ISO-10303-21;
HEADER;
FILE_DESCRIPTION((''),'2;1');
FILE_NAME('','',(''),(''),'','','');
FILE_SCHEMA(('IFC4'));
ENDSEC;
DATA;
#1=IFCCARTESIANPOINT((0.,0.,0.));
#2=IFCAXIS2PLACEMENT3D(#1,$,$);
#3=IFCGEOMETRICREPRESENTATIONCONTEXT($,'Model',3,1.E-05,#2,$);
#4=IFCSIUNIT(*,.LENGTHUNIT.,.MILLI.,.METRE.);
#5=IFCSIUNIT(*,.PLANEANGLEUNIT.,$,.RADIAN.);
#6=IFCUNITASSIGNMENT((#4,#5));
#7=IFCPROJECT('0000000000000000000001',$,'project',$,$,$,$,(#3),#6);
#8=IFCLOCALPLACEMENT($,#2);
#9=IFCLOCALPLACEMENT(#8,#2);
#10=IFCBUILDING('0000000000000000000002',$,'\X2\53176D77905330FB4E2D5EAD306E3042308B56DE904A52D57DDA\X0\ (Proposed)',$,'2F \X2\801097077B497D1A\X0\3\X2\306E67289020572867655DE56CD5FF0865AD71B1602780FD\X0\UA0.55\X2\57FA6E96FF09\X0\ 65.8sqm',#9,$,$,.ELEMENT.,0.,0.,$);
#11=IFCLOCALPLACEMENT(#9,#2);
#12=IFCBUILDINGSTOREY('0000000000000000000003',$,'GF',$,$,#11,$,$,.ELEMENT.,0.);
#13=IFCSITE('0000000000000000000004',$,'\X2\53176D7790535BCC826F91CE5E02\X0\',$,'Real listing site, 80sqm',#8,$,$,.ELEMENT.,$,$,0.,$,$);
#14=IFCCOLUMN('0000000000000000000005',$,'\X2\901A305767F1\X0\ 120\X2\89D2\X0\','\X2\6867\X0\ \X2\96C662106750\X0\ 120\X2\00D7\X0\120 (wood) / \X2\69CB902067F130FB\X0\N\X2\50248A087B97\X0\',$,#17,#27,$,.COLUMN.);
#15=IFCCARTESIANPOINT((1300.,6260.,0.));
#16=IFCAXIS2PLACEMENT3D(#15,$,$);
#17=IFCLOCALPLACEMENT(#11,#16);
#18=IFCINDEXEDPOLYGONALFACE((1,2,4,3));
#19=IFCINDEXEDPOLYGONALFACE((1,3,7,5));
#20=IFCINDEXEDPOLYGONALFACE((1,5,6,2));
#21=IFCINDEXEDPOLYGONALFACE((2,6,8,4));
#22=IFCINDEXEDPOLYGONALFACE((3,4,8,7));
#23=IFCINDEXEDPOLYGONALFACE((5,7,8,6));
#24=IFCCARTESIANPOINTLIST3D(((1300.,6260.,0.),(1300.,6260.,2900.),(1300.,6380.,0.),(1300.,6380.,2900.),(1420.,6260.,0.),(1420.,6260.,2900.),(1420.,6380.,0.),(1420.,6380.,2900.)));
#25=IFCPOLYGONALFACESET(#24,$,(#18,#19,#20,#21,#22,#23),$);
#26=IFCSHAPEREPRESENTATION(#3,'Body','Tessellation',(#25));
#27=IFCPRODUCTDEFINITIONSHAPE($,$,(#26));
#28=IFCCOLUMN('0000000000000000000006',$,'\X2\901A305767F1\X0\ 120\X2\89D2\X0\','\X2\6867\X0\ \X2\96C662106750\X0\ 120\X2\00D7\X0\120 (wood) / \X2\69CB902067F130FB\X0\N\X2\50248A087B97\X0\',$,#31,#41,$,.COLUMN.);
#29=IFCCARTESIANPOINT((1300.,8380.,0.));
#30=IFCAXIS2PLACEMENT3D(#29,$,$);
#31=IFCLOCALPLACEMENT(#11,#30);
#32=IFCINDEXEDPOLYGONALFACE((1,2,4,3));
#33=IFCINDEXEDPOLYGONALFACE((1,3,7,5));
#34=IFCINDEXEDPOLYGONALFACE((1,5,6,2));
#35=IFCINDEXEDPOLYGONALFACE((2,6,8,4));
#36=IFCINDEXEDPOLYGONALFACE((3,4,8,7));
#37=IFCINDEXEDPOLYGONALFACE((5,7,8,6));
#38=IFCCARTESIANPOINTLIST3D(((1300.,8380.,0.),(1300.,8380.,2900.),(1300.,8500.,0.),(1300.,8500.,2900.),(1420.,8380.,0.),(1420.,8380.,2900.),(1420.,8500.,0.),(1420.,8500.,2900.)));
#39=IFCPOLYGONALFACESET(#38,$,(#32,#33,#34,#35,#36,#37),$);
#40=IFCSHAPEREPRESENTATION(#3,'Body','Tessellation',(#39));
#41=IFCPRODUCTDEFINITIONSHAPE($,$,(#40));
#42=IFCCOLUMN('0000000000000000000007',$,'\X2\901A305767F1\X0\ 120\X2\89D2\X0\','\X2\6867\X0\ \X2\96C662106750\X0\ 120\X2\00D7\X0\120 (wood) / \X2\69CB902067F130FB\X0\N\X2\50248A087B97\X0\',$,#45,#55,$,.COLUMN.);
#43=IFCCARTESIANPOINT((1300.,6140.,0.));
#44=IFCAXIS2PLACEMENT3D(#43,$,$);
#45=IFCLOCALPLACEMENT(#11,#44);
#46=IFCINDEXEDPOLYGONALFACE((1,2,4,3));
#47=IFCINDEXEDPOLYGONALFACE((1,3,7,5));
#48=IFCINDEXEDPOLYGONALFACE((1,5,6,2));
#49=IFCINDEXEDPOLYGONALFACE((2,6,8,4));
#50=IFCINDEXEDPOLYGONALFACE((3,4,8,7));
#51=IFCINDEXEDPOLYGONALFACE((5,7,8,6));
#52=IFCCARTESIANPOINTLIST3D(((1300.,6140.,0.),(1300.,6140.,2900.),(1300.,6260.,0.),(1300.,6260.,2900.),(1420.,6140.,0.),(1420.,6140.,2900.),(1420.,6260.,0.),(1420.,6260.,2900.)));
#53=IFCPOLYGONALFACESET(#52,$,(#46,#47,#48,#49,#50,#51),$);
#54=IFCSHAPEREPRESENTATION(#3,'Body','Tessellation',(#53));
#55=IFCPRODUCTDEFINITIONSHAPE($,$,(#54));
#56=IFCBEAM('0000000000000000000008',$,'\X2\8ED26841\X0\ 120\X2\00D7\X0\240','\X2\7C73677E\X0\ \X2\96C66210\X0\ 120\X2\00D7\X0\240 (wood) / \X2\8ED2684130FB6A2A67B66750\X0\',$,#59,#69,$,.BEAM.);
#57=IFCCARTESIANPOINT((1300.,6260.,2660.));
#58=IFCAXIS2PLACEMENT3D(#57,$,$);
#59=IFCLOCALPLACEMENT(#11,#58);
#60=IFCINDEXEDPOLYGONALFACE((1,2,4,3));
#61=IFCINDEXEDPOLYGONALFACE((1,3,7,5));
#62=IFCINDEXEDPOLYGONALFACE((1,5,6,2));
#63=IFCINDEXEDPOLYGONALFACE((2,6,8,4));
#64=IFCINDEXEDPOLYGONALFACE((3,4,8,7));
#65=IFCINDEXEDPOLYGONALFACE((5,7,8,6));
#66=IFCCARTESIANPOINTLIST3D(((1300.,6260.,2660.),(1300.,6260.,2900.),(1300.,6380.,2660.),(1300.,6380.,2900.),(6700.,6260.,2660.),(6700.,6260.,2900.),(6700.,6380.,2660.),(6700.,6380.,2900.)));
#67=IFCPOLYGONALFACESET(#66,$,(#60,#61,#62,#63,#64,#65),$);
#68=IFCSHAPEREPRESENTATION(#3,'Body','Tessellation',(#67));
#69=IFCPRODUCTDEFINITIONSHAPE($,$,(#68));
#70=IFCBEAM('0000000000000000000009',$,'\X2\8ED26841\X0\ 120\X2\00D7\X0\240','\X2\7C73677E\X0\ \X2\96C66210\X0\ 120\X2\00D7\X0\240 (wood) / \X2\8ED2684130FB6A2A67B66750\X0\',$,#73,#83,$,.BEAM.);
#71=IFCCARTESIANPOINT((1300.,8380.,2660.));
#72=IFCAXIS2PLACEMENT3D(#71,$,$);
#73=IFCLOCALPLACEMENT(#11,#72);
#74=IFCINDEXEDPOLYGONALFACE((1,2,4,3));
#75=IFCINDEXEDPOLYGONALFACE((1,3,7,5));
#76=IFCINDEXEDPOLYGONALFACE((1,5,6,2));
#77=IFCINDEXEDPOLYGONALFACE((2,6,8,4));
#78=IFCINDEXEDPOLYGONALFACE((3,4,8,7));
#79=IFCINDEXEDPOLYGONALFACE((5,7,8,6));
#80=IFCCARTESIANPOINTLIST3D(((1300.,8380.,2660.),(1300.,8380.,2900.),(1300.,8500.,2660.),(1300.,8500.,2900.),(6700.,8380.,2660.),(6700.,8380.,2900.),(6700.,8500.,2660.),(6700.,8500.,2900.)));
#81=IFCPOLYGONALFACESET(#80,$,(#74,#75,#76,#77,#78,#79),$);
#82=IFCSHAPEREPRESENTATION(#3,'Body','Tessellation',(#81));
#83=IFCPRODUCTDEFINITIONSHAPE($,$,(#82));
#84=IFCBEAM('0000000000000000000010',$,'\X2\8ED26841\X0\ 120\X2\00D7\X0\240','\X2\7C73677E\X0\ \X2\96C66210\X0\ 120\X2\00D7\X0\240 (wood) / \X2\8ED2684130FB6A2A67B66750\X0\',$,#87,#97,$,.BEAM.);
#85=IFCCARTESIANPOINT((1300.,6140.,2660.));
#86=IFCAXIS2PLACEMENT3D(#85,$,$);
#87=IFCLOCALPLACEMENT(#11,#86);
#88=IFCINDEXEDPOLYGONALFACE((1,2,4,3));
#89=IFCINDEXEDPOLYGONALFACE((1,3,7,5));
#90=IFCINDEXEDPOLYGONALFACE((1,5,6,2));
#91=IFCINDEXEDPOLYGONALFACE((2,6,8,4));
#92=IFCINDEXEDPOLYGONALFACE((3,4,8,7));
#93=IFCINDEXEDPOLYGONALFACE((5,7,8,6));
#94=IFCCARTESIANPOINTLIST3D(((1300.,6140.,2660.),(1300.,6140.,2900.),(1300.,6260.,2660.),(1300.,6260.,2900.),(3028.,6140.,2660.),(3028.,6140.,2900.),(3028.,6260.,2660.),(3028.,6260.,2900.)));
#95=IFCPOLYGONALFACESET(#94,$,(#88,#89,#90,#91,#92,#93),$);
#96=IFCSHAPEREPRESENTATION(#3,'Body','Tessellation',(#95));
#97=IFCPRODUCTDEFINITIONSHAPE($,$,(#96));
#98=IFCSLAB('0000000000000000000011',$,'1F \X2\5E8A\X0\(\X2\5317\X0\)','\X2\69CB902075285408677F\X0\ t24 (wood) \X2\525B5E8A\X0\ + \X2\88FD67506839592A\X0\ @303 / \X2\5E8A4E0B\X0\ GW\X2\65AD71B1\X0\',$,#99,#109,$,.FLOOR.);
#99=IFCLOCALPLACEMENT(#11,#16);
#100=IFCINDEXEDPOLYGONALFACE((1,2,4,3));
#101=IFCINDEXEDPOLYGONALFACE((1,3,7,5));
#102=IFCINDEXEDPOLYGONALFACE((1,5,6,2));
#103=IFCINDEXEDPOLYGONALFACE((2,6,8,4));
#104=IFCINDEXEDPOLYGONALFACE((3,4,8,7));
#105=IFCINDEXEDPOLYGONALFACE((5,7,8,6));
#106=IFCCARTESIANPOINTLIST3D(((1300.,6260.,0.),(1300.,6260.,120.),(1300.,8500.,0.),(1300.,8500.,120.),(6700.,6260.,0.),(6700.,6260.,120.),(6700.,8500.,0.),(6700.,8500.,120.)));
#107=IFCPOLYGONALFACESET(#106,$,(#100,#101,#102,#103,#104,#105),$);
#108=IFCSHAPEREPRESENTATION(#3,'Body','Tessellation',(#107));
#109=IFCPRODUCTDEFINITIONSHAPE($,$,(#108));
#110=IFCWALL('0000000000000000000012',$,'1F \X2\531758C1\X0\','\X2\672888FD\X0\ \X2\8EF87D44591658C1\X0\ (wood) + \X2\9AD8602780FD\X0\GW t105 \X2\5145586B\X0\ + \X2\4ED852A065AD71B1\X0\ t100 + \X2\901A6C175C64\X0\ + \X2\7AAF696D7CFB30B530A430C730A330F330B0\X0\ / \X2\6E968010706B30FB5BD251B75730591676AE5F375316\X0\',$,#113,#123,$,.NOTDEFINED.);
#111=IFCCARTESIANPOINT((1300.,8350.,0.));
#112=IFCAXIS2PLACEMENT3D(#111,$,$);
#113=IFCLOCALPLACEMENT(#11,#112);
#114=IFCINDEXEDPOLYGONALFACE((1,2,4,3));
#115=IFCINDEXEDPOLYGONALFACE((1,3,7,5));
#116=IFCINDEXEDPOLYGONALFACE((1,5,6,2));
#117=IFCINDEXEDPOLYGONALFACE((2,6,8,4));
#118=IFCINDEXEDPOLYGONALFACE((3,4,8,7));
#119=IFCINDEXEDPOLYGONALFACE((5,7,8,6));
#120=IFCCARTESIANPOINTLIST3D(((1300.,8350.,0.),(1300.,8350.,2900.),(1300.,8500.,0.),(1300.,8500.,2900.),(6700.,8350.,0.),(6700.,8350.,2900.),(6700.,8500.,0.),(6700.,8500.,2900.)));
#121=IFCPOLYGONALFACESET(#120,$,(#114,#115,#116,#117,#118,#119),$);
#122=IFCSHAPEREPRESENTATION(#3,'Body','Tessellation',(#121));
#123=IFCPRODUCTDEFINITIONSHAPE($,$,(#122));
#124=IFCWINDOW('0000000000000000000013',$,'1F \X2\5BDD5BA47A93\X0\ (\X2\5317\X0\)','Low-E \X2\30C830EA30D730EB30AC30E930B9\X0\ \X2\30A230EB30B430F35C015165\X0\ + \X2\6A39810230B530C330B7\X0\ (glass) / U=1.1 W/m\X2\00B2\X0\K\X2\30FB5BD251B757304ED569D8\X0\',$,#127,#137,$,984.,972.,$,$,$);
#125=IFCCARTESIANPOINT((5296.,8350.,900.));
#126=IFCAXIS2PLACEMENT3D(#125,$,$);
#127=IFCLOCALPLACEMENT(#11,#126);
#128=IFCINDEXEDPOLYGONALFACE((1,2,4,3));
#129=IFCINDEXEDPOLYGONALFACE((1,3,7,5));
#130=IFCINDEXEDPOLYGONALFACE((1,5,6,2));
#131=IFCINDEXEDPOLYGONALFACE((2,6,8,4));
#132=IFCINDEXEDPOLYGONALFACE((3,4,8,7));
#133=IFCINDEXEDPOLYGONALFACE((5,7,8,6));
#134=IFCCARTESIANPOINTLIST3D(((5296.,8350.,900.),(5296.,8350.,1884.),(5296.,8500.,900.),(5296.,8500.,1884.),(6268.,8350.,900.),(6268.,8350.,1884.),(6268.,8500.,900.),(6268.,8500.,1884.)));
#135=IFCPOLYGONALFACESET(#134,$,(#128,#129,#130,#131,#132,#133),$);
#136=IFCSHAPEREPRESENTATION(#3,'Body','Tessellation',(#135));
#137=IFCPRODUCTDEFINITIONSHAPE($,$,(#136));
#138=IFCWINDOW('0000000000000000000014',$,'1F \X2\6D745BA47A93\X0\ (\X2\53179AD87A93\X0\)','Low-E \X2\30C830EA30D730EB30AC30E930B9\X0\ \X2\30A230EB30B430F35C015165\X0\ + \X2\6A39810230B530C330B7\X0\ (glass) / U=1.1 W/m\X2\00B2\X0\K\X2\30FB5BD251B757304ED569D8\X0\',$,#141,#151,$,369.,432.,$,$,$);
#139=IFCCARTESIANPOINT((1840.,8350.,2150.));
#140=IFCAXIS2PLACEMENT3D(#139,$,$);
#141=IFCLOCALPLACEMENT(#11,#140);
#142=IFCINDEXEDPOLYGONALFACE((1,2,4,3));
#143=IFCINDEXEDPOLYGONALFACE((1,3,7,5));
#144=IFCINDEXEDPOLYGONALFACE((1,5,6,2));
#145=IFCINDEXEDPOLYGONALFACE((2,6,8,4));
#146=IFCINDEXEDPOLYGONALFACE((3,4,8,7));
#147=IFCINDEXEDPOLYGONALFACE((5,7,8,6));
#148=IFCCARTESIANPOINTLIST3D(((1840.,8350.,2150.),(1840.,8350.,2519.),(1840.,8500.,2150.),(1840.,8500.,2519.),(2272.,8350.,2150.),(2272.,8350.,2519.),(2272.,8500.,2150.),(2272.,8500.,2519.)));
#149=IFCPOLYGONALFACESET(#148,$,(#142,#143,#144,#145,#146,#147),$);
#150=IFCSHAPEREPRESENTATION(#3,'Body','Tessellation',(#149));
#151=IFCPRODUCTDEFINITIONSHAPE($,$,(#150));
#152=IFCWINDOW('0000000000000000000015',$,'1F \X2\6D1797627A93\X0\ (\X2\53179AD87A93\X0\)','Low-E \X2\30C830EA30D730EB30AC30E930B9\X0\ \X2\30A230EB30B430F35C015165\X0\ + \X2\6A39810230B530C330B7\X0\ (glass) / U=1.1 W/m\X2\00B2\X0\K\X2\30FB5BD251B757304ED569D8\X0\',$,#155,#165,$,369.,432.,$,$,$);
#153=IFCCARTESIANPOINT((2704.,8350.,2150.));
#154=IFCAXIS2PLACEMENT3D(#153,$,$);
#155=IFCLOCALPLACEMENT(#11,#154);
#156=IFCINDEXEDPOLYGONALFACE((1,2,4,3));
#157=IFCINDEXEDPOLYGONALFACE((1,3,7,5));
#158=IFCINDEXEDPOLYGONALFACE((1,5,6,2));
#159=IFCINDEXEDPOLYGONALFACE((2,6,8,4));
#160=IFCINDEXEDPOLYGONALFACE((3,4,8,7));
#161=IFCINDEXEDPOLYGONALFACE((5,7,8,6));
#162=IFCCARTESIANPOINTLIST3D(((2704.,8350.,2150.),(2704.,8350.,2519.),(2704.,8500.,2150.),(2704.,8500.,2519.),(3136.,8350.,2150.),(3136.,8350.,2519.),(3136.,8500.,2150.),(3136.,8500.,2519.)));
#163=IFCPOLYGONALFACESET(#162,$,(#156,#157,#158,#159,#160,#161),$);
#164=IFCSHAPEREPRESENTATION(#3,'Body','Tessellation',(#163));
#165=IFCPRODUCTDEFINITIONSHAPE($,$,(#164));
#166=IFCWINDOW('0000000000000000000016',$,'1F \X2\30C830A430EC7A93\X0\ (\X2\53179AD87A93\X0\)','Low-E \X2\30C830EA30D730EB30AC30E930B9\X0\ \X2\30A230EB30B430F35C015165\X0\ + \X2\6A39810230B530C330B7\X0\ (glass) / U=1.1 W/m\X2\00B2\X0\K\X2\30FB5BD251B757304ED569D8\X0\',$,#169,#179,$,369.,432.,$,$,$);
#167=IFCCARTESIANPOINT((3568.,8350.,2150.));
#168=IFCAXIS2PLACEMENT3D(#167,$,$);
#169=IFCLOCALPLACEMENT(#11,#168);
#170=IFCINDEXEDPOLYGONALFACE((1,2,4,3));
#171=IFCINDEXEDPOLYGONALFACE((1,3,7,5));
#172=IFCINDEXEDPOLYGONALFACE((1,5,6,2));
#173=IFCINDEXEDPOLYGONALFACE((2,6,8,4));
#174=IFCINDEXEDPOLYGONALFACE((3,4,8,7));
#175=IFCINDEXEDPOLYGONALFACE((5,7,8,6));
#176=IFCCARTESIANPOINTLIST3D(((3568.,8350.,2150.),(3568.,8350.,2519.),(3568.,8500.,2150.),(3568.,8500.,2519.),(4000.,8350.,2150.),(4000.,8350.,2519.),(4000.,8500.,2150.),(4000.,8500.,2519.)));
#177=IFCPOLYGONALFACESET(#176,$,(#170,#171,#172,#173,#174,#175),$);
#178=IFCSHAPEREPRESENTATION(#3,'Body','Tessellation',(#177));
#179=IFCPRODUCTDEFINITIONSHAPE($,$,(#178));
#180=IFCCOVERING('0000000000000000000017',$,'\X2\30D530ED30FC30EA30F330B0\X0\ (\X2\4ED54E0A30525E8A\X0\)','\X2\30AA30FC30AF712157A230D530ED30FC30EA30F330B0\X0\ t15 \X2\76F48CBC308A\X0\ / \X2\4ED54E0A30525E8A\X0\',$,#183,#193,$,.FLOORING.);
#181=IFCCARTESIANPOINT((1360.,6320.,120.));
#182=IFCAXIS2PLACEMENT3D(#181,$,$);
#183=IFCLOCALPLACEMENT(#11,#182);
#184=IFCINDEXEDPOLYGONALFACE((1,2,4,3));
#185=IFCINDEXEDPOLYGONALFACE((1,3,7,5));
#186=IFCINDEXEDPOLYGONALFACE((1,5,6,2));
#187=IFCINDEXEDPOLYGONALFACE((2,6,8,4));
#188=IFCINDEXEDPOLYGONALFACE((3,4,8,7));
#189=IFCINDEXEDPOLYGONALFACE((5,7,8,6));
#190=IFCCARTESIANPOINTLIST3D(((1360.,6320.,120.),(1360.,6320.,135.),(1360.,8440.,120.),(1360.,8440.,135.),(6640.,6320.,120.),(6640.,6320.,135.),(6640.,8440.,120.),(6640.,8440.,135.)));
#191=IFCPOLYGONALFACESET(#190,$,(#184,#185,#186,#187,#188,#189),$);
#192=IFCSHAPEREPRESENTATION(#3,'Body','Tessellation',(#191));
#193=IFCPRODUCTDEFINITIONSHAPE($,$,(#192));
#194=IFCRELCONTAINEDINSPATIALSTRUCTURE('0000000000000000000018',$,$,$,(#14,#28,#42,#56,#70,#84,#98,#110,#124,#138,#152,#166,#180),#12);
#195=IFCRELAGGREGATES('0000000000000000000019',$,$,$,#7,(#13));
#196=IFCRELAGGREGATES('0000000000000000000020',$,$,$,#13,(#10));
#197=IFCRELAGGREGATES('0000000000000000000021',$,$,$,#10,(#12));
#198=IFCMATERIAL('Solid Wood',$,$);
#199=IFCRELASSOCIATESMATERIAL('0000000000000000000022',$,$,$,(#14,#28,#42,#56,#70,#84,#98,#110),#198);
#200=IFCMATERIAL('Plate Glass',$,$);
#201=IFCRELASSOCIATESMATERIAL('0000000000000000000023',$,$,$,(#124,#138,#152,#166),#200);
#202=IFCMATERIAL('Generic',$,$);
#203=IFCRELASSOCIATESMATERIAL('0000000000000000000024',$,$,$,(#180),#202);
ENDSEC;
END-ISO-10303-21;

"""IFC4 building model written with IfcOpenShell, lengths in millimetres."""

from ifc_helpers import new_model, si_unit, frame, frame_2d, origin, place, context, project, spatial, rectangle, extrude, material, element, fill, save


model = new_model("IFC4")

# Units and contexts
model_context = context("Model", 3, precision=1e-05, world=origin())
ifc_project = project(units=[si_unit("LENGTHUNIT", "METRE", prefix="MILLI"), si_unit("PLANEANGLEUNIT", "RADIAN")], contexts=[model_context])

# Site, building, storey
site_placement = place(None, origin())
site = spatial("IfcSite", under=ifc_project, at=site_placement, Name="北海道富良野市", ObjectType="Real listing site, 80sqm", CompositionType="ELEMENT", RefElevation=0.0)
building_placement = place(site_placement, origin())
building = spatial("IfcBuilding", under=site, at=building_placement, Name="北海道・中庭のある回遊動線 (Proposed)", ObjectType="2F 耐震等級3の木造在来工法（断熱性能UA0.55基準） 65.8sqm", CompositionType="ELEMENT", ElevationOfRefHeight=0.0, ElevationOfTerrain=0.0)
storey_placement = place(building_placement, origin())
storey = spatial("IfcBuildingStorey", under=building, at=storey_placement, Name="GF", CompositionType="ELEMENT", Elevation=0.0)

# Columns
ifc_material_1 = material(Name="Solid Wood")
column_1_placement = place(storey_placement, frame((1300.0, 6260.0, 0.0)))
element("IfcColumn", 1, at=column_1_placement, inside=storey, material=ifc_material_1, Name="通し柱 120角", Description="桧 集成材 120×120 (wood) / 構造柱・N値計算", PredefinedType="COLUMN", context=model_context, shape_type="SweptSolid", body=[
    extrude(rectangle(XDim=120.0, YDim=120.0, at=frame_2d((60.0, 60.0))), frame((1300.0, 6260.0, 0.0)), (0.0, 0.0, 1.0), 2900.0),
])
column_2_placement = place(storey_placement, frame((1300.0, 8380.0, 0.0)))
element("IfcColumn", 2, at=column_2_placement, inside=storey, material=ifc_material_1, Name="通し柱 120角", Description="桧 集成材 120×120 (wood) / 構造柱・N値計算", PredefinedType="COLUMN", context=model_context, shape_type="SweptSolid", body=[
    extrude(rectangle(XDim=120.0, YDim=120.0, at=frame_2d((60.0, 60.0))), frame((1300.0, 8380.0, 0.0)), (0.0, 0.0, 1.0), 2900.0),
])
column_3_placement = place(storey_placement, frame((1300.0, 6140.0, 0.0)))
element("IfcColumn", 3, at=column_3_placement, inside=storey, material=ifc_material_1, Name="通し柱 120角", Description="桧 集成材 120×120 (wood) / 構造柱・N値計算", PredefinedType="COLUMN", context=model_context, shape_type="SweptSolid", body=[
    extrude(rectangle(XDim=120.0, YDim=120.0, at=frame_2d((60.0, 60.0))), frame((1300.0, 6140.0, 0.0)), (0.0, 0.0, 1.0), 2900.0),
])

# Beams
beam_1_placement = place(storey_placement, frame((1300.0, 6260.0, 2660.0)))
element("IfcBeam", 4, at=beam_1_placement, inside=storey, material=ifc_material_1, Name="軒桁 120×240", Description="米松 集成 120×240 (wood) / 軒桁・横架材", PredefinedType="BEAM", context=model_context, shape_type="SweptSolid", body=[
    extrude(rectangle(XDim=5400.0, YDim=120.0, at=frame_2d((2700.0, 60.0))), frame((1300.0, 6260.0, 2660.0)), (0.0, 0.0, 1.0), 240.0),
])
beam_2_placement = place(storey_placement, frame((1300.0, 8380.0, 2660.0)))
element("IfcBeam", 5, at=beam_2_placement, inside=storey, material=ifc_material_1, Name="軒桁 120×240", Description="米松 集成 120×240 (wood) / 軒桁・横架材", PredefinedType="BEAM", context=model_context, shape_type="SweptSolid", body=[
    extrude(rectangle(XDim=5400.0, YDim=120.0, at=frame_2d((2700.0, 60.0))), frame((1300.0, 8380.0, 2660.0)), (0.0, 0.0, 1.0), 240.0),
])
beam_3_placement = place(storey_placement, frame((1300.0, 6140.0, 2660.0)))
element("IfcBeam", 6, at=beam_3_placement, inside=storey, material=ifc_material_1, Name="軒桁 120×240", Description="米松 集成 120×240 (wood) / 軒桁・横架材", PredefinedType="BEAM", context=model_context, shape_type="SweptSolid", body=[
    extrude(rectangle(XDim=1728.0, YDim=120.0, at=frame_2d((864.0, 60.0))), frame((1300.0, 6140.0, 2660.0)), (0.0, 0.0, 1.0), 240.0),
])

# Slab
slab_placement = place(storey_placement, frame((1300.0, 6260.0, 0.0)))
element("IfcSlab", 7, at=slab_placement, inside=storey, material=ifc_material_1, Name="1F 床(北)", Description="構造用合板 t24 (wood) 剛床 + 製材根太 @303 / 床下 GW断熱", PredefinedType="FLOOR", context=model_context, shape_type="SweptSolid", body=[
    extrude(rectangle(XDim=5400.0, YDim=2240.0, at=frame_2d((2700.0, 1120.0))), frame((1300.0, 6260.0, 0.0)), (0.0, 0.0, 1.0), 120.0),
])

# Wall, openings, windows
wall_1_placement = place(storey_placement, frame((1300.0, 8350.0, 0.0)))
wall_1 = element("IfcWall", 8, at=wall_1_placement, inside=storey, material=ifc_material_1, Name="1F 北壁", Description="木製 軸組外壁 (wood) + 高性能GW t105 充填 + 付加断熱 t100 + 通気層 + 窯業系サイディング / 準耐火・寒冷地外皮強化", PredefinedType="NOTDEFINED", context=model_context, shape_type="SweptSolid", body=[
    extrude(rectangle(XDim=5400.0, YDim=150.0, at=frame_2d((2700.0, 75.0))), frame((1300.0, 8350.0, 0.0)), (0.0, 0.0, 1.0), 2900.0),
])
opening_1_placement = place(storey_placement, frame((5296.0, 8350.0, 900.0)))
opening_1 = element("IfcOpeningElement", 9, at=opening_1_placement, cuts=wall_1, PredefinedType="NOTDEFINED", context=model_context, shape_type="SweptSolid", body=[
    extrude(rectangle(XDim=972.0, YDim=150.0, at=frame_2d((486.0, 75.0))), frame((5296.0, 8350.0, 900.0)), (0.0, 0.0, 1.0), 984.0),
])
opening_2_placement = place(storey_placement, frame((1840.0, 8350.0, 2150.0)))
opening_2 = element("IfcOpeningElement", 10, at=opening_2_placement, cuts=wall_1, PredefinedType="NOTDEFINED", context=model_context, shape_type="SweptSolid", body=[
    extrude(rectangle(XDim=432.0, YDim=150.0, at=frame_2d((216.0, 75.0))), frame((1840.0, 8350.0, 2150.0)), (0.0, 0.0, 1.0), 369.0),
])
opening_3_placement = place(storey_placement, frame((2704.0, 8350.0, 2150.0)))
opening_3 = element("IfcOpeningElement", 11, at=opening_3_placement, cuts=wall_1, PredefinedType="NOTDEFINED", context=model_context, shape_type="SweptSolid", body=[
    extrude(rectangle(XDim=432.0, YDim=150.0, at=frame_2d((216.0, 75.0))), frame((2704.0, 8350.0, 2150.0)), (0.0, 0.0, 1.0), 369.0),
])
opening_4_placement = place(storey_placement, frame((3568.0, 8350.0, 2150.0)))
opening_4 = element("IfcOpeningElement", 12, at=opening_4_placement, cuts=wall_1, PredefinedType="NOTDEFINED", context=model_context, shape_type="SweptSolid", body=[
    extrude(rectangle(XDim=432.0, YDim=150.0, at=frame_2d((216.0, 75.0))), frame((3568.0, 8350.0, 2150.0)), (0.0, 0.0, 1.0), 369.0),
])
ifc_material_2 = material(Name="Plate Glass")
window_1_placement = place(storey_placement, frame((5296.0, 8350.0, 900.0)))
window_1 = element("IfcWindow", 13, at=window_1_placement, inside=storey, material=ifc_material_2, Name="1F 寝室窓 (北)", Description="Low-E トリプルガラス アルゴン封入 + 樹脂サッシ (glass) / U=1.1 W/m²K・寒冷地仕様", OverallHeight=984.0, OverallWidth=972.0, context=model_context, shape_type="SweptSolid", body=[
    extrude(rectangle(XDim=972.0, YDim=150.0, at=frame_2d((486.0, 75.0))), frame((5296.0, 8350.0, 900.0)), (0.0, 0.0, 1.0), 984.0),
])
fill(opening_1, window_1)
window_2_placement = place(storey_placement, frame((1840.0, 8350.0, 2150.0)))
window_2 = element("IfcWindow", 14, at=window_2_placement, inside=storey, material=ifc_material_2, Name="1F 浴室窓 (北高窓)", Description="Low-E トリプルガラス アルゴン封入 + 樹脂サッシ (glass) / U=1.1 W/m²K・寒冷地仕様", OverallHeight=369.0, OverallWidth=432.0, context=model_context, shape_type="SweptSolid", body=[
    extrude(rectangle(XDim=432.0, YDim=150.0, at=frame_2d((216.0, 75.0))), frame((1840.0, 8350.0, 2150.0)), (0.0, 0.0, 1.0), 369.0),
])
fill(opening_2, window_2)
window_3_placement = place(storey_placement, frame((2704.0, 8350.0, 2150.0)))
window_3 = element("IfcWindow", 15, at=window_3_placement, inside=storey, material=ifc_material_2, Name="1F 洗面窓 (北高窓)", Description="Low-E トリプルガラス アルゴン封入 + 樹脂サッシ (glass) / U=1.1 W/m²K・寒冷地仕様", OverallHeight=369.0, OverallWidth=432.0, context=model_context, shape_type="SweptSolid", body=[
    extrude(rectangle(XDim=432.0, YDim=150.0, at=frame_2d((216.0, 75.0))), frame((2704.0, 8350.0, 2150.0)), (0.0, 0.0, 1.0), 369.0),
])
fill(opening_3, window_3)
window_4_placement = place(storey_placement, frame((3568.0, 8350.0, 2150.0)))
window_4 = element("IfcWindow", 16, at=window_4_placement, inside=storey, material=ifc_material_2, Name="1F トイレ窓 (北高窓)", Description="Low-E トリプルガラス アルゴン封入 + 樹脂サッシ (glass) / U=1.1 W/m²K・寒冷地仕様", OverallHeight=369.0, OverallWidth=432.0, context=model_context, shape_type="SweptSolid", body=[
    extrude(rectangle(XDim=432.0, YDim=150.0, at=frame_2d((216.0, 75.0))), frame((3568.0, 8350.0, 2150.0)), (0.0, 0.0, 1.0), 369.0),
])
fill(opening_4, window_4)

# Covering
ifc_material_3 = material(Name="Generic")
covering_1_placement = place(storey_placement, frame((1360.0, 6320.0, 120.0)))
element("IfcCovering", 17, at=covering_1_placement, inside=storey, material=ifc_material_3, Name="フローリング (仕上げ床)", Description="オーク無垢フローリング t15 直貼り / 仕上げ床", PredefinedType="FLOORING", context=model_context, shape_type="SweptSolid", body=[
    extrude(rectangle(XDim=5280.0, YDim=2120.0, at=frame_2d((2640.0, 1060.0))), frame((1360.0, 6320.0, 120.0)), (0.0, 0.0, 1.0), 15.0),
])

save(model, "model.ifc")
